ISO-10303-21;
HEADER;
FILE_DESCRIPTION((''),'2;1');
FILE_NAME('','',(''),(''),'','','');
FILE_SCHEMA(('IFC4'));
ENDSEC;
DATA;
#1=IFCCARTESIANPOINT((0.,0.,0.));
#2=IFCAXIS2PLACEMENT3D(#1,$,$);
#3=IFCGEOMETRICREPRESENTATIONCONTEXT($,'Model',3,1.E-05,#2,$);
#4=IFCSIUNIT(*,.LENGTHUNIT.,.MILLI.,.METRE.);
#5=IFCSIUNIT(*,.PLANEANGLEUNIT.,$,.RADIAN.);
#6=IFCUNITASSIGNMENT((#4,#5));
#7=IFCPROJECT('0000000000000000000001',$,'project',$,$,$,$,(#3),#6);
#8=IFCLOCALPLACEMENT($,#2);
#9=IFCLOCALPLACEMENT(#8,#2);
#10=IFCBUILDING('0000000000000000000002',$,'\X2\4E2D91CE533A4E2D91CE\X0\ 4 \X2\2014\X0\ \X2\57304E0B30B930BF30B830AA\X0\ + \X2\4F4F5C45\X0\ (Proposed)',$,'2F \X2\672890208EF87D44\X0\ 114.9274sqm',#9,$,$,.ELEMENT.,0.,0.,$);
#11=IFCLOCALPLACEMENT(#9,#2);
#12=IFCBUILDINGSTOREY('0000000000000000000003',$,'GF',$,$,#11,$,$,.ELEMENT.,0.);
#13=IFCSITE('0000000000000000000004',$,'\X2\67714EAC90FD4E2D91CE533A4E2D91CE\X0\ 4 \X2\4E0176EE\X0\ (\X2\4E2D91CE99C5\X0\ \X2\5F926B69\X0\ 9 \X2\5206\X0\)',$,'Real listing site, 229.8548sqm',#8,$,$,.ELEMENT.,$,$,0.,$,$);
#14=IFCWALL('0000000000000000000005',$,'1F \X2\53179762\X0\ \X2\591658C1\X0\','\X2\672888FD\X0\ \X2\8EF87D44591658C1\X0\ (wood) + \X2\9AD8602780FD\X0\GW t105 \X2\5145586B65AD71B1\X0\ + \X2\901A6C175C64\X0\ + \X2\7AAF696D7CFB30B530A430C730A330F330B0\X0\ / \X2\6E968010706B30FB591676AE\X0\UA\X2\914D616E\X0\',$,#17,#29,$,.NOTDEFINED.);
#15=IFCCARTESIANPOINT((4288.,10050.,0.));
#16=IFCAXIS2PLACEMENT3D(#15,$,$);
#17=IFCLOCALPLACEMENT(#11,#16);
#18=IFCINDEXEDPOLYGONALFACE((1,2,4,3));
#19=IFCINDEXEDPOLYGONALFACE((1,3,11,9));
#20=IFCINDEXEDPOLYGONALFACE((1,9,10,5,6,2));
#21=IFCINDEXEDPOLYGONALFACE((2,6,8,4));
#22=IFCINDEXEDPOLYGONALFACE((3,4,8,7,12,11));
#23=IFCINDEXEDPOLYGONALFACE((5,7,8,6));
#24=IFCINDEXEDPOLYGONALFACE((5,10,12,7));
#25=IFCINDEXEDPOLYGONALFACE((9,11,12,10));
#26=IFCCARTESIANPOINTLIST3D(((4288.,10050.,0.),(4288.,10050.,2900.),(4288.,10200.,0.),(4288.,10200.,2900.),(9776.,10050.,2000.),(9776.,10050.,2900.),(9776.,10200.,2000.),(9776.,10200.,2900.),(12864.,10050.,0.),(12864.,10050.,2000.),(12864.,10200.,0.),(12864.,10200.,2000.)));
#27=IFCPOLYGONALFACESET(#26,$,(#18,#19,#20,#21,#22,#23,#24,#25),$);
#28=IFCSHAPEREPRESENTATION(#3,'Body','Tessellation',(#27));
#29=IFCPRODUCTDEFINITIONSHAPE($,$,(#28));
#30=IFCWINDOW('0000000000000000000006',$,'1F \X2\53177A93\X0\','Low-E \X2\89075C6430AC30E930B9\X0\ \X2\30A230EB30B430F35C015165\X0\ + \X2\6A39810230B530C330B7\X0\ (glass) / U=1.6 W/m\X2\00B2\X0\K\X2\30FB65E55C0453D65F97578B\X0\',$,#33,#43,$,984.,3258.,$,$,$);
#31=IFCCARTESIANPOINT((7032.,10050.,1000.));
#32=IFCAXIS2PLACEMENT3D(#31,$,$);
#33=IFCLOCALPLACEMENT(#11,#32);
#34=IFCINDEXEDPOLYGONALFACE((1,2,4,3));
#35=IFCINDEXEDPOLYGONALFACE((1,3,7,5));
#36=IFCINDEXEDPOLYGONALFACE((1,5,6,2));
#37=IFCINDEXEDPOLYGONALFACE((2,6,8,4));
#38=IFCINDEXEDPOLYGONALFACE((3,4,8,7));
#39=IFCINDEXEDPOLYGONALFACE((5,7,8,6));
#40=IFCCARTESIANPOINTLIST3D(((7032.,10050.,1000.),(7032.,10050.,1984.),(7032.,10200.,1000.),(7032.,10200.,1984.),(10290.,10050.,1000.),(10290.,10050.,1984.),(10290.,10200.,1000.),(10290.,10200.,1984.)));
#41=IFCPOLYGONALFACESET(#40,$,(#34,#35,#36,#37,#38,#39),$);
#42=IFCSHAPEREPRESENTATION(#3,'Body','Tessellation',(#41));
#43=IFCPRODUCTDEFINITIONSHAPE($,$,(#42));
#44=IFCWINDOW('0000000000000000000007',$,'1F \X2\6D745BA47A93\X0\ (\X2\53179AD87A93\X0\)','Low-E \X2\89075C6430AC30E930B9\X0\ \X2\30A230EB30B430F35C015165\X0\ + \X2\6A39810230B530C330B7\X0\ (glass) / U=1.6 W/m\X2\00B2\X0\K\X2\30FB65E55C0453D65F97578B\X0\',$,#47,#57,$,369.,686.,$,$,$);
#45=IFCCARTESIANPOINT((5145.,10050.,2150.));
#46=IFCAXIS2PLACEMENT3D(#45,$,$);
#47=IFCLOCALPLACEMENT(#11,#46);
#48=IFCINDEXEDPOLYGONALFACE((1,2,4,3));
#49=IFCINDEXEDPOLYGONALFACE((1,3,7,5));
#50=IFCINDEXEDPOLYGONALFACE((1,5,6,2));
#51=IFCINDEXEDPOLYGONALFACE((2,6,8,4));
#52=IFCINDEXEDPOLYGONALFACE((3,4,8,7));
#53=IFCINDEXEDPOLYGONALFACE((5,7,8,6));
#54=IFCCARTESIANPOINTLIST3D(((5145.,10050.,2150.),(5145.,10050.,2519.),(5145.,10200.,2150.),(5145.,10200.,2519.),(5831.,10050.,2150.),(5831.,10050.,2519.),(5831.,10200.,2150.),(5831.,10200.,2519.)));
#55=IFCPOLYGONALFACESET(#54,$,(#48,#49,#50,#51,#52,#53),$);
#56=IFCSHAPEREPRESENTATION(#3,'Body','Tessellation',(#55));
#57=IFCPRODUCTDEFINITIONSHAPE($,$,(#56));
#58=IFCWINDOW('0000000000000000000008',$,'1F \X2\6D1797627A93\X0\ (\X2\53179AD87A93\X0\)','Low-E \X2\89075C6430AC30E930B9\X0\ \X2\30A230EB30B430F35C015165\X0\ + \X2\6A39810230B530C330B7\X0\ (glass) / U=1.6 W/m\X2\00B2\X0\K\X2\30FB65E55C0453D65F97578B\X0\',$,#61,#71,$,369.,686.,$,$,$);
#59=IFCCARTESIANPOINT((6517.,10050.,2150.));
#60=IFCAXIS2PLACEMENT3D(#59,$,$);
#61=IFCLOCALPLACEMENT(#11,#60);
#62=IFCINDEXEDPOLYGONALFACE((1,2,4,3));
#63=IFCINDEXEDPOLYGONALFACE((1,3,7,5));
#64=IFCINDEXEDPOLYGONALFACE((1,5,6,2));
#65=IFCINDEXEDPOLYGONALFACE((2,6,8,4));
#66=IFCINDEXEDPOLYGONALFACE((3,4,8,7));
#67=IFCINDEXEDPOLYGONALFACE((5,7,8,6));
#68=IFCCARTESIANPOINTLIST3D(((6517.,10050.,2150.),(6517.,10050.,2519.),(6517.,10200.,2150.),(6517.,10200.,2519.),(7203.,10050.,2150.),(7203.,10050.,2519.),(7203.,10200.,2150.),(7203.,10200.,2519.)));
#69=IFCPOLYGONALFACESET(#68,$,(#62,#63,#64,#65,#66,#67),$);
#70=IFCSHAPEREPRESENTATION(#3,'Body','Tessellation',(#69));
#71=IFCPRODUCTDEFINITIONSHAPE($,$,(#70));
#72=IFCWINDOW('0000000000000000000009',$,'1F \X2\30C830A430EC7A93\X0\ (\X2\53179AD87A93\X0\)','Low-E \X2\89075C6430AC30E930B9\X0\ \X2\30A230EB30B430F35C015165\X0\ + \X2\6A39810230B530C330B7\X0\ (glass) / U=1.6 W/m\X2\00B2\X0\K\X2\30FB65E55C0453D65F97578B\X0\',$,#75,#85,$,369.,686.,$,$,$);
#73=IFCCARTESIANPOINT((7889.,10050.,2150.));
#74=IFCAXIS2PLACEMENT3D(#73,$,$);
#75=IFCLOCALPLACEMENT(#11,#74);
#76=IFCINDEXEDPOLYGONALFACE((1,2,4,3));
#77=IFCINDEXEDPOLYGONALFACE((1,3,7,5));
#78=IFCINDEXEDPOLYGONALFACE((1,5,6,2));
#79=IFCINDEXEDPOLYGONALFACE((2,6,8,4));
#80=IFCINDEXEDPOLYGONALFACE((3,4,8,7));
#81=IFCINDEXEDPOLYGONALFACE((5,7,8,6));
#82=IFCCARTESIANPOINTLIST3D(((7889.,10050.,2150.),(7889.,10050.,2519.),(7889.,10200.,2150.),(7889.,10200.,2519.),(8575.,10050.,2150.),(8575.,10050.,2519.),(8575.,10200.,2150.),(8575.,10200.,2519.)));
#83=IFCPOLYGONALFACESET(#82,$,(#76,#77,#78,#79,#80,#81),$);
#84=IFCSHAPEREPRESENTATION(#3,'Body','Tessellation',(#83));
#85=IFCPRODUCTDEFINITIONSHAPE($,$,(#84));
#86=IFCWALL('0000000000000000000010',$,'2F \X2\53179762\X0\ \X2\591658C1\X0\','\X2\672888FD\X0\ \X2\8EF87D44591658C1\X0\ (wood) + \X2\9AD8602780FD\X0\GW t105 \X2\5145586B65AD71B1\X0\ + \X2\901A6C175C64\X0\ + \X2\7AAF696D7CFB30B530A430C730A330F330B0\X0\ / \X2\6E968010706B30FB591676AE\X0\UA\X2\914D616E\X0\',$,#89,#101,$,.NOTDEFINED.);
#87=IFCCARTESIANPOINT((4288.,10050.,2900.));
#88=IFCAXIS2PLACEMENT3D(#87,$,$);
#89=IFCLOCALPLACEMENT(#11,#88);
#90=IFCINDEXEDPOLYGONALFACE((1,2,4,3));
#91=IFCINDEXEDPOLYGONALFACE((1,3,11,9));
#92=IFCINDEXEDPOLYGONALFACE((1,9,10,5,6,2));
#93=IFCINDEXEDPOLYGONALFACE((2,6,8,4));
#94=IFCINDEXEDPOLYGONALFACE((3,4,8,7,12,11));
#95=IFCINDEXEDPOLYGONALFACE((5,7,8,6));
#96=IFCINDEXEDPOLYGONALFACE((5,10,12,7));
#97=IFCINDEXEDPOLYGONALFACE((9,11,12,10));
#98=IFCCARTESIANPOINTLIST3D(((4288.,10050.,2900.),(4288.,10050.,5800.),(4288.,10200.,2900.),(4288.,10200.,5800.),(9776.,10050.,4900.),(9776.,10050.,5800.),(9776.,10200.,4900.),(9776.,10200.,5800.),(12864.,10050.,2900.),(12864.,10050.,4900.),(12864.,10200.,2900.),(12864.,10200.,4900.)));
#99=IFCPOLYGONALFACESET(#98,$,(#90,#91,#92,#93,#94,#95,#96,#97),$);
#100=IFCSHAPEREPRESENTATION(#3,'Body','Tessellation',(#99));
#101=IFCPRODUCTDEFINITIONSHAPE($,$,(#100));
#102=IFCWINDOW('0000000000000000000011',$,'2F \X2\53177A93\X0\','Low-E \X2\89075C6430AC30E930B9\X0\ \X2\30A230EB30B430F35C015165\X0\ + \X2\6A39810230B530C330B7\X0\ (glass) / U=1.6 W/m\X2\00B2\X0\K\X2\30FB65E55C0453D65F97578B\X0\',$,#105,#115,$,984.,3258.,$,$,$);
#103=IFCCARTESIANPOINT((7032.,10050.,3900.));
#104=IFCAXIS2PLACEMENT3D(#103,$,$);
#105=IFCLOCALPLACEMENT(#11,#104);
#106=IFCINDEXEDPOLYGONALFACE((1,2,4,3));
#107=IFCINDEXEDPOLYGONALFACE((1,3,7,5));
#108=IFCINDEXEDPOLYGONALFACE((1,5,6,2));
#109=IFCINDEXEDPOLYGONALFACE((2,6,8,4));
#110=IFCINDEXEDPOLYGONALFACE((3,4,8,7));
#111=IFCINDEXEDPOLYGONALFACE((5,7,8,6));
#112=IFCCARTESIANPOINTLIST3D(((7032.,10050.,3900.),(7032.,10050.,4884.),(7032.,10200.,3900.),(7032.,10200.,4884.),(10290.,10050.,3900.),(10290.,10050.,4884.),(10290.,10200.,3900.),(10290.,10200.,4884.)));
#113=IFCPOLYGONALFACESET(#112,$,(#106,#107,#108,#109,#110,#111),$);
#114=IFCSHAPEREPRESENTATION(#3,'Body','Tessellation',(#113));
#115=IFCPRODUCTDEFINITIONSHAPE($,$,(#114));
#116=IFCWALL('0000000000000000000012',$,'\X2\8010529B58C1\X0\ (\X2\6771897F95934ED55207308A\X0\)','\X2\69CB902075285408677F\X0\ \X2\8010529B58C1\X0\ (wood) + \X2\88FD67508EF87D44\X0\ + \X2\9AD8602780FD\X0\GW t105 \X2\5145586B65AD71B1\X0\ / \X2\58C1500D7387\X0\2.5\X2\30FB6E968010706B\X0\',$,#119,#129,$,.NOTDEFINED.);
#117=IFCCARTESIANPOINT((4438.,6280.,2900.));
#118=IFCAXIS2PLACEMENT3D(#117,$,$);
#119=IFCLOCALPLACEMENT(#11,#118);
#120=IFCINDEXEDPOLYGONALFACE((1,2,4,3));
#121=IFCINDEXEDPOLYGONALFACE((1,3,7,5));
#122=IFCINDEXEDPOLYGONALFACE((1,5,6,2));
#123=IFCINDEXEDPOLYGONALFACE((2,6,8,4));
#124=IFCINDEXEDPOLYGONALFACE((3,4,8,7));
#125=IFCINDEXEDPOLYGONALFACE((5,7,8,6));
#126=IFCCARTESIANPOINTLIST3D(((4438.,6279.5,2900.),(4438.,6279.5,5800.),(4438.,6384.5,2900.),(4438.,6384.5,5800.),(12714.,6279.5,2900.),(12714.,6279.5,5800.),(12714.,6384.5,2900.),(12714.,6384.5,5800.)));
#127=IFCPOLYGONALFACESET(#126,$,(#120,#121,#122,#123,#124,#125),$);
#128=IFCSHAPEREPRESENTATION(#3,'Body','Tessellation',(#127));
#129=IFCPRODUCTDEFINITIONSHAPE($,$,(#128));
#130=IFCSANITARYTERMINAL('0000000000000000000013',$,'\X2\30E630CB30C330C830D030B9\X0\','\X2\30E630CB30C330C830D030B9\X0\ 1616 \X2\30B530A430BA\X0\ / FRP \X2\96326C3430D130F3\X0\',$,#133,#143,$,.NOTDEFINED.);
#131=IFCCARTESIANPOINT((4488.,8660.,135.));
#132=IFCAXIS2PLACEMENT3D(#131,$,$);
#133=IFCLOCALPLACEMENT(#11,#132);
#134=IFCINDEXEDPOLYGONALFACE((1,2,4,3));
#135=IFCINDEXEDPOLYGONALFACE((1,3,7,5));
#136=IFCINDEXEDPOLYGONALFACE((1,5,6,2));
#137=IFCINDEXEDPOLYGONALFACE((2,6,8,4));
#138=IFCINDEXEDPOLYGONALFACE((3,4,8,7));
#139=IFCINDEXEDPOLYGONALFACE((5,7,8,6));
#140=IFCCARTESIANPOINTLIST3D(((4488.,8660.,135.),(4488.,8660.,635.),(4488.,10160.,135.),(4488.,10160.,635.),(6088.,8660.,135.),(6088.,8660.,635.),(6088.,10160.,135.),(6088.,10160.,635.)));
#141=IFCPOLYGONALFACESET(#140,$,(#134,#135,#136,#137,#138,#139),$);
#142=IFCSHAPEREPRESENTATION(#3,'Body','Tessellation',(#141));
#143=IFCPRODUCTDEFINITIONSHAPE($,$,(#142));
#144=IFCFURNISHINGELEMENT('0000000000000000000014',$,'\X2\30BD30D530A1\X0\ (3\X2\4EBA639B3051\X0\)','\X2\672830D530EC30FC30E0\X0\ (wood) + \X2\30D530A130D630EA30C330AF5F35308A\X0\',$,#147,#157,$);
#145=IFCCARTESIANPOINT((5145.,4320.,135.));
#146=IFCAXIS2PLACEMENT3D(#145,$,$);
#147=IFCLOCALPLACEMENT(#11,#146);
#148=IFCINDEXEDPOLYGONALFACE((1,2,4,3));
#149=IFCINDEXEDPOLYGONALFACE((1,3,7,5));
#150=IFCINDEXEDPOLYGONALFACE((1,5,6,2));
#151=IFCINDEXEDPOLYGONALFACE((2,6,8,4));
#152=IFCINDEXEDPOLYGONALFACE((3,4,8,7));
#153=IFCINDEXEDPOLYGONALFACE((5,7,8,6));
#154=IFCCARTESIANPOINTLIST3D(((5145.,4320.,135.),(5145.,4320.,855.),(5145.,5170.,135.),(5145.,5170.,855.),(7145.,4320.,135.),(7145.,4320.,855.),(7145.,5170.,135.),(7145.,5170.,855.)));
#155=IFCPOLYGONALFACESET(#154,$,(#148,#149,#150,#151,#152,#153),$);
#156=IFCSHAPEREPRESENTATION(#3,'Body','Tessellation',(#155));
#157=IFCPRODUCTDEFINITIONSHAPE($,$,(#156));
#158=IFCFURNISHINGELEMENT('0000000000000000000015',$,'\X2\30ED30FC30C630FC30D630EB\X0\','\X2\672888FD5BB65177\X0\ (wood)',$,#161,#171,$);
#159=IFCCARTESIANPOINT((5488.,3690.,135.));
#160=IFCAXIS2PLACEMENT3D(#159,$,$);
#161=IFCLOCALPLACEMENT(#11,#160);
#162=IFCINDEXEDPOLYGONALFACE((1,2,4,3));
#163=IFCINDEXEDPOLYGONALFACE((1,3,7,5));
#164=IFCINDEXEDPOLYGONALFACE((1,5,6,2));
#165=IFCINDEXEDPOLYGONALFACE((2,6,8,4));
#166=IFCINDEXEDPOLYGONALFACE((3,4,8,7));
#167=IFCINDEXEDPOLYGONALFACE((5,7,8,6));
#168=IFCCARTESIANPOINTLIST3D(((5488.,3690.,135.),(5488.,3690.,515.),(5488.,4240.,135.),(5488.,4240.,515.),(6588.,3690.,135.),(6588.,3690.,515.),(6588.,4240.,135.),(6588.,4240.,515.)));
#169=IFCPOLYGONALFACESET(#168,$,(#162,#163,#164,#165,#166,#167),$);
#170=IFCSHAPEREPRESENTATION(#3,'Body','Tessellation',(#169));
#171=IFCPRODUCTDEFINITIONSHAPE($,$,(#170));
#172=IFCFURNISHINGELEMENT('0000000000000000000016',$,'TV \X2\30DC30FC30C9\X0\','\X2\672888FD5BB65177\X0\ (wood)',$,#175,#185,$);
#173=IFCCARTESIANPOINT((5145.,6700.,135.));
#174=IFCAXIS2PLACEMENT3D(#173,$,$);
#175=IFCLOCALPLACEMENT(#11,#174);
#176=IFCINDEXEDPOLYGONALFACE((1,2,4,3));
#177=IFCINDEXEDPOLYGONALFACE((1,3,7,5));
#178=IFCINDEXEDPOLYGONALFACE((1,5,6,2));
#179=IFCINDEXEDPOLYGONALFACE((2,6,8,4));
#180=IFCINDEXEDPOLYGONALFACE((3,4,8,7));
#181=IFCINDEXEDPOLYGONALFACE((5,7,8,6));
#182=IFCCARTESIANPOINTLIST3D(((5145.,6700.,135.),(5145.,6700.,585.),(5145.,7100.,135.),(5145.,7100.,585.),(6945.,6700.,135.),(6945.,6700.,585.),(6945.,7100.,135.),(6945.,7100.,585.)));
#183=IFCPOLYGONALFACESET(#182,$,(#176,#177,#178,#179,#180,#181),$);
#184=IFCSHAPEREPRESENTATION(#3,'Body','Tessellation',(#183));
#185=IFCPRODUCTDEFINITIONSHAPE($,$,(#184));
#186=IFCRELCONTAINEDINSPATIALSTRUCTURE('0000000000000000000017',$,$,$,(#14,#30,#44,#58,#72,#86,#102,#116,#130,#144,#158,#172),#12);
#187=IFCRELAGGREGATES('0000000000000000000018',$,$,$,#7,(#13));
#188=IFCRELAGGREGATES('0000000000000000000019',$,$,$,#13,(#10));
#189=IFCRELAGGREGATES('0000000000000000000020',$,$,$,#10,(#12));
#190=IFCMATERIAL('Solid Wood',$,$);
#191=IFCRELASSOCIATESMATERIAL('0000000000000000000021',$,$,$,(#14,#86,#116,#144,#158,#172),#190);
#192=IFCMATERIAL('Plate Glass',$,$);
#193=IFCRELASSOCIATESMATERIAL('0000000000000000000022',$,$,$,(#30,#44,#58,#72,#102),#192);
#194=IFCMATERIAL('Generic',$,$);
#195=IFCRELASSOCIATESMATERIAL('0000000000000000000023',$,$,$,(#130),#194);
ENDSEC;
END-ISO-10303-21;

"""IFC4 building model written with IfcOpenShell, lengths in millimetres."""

from ifc_helpers import new_model, si_unit, frame, frame_2d, origin, place, context, project, spatial, rectangle, extrude, material, element, fill, save


model = new_model("IFC4")

# Units and contexts
model_context = context("Model", 3, precision=1e-05, world=origin())
ifc_project = project(units=[si_unit("LENGTHUNIT", "METRE", prefix="MILLI"), si_unit("PLANEANGLEUNIT", "RADIAN")], contexts=[model_context])

# Site, building, storey
site_placement = place(None, origin())
site = spatial("IfcSite", under=ifc_project, at=site_placement, Name="東京都中野区中野 4 丁目 (中野駅 徒歩 9 分)", ObjectType="Real listing site, 229.8548sqm", CompositionType="ELEMENT", RefElevation=0.0)
building_placement = place(site_placement, origin())
building = spatial("IfcBuilding", under=site, at=building_placement, Name="中野区中野 4 — 地下スタジオ + 住居 (Proposed)", ObjectType="2F 木造軸組 114.9274sqm", CompositionType="ELEMENT", ElevationOfRefHeight=0.0, ElevationOfTerrain=0.0)
storey_placement = place(building_placement, origin())
storey = spatial("IfcBuildingStorey", under=building, at=storey_placement, Name="GF", CompositionType="ELEMENT", Elevation=0.0)

# Wall, openings, windows
ifc_material_1 = material(Name="Solid Wood")
wall_1_placement = place(storey_placement, frame((4288.0, 10050.0, 0.0)))
wall_1 = element("IfcWall", 1, at=wall_1_placement, inside=storey, material=ifc_material_1, Name="1F 北面 外壁", Description="木製 軸組外壁 (wood) + 高性能GW t105 充填断熱 + 通気層 + 窯業系サイディング / 準耐火・外皮UA配慮", PredefinedType="NOTDEFINED", context=model_context, shape_type="SweptSolid", body=[
    extrude(rectangle(XDim=8576.0, YDim=150.0, at=frame_2d((4288.0, 75.0))), frame((4288.0, 10050.0, 0.0)), (0.0, 0.0, 1.0), 2900.0),
])
opening_1_placement = place(storey_placement, frame((7032.0, 10050.0, 1000.0)))
opening_1 = element("IfcOpeningElement", 2, at=opening_1_placement, cuts=wall_1, PredefinedType="NOTDEFINED", context=model_context, shape_type="SweptSolid", body=[
    extrude(rectangle(XDim=3258.0, YDim=150.0, at=frame_2d((1629.0, 75.0))), frame((7032.0, 10050.0, 1000.0)), (0.0, 0.0, 1.0), 984.0),
])
opening_2_placement = place(storey_placement, frame((5145.0, 10050.0, 2150.0)))
opening_2 = element("IfcOpeningElement", 3, at=opening_2_placement, cuts=wall_1, PredefinedType="NOTDEFINED", context=model_context, shape_type="SweptSolid", body=[
    extrude(rectangle(XDim=686.0, YDim=150.0, at=frame_2d((343.0, 75.0))), frame((5145.0, 10050.0, 2150.0)), (0.0, 0.0, 1.0), 369.0),
])
opening_3_placement = place(storey_placement, frame((6517.0, 10050.0, 2150.0)))
opening_3 = element("IfcOpeningElement", 4, at=opening_3_placement, cuts=wall_1, PredefinedType="NOTDEFINED", context=model_context, shape_type="SweptSolid", body=[
    extrude(rectangle(XDim=686.0, YDim=150.0, at=frame_2d((343.0, 75.0))), frame((6517.0, 10050.0, 2150.0)), (0.0, 0.0, 1.0), 369.0),
])
opening_4_placement = place(storey_placement, frame((7889.0, 10050.0, 2150.0)))
opening_4 = element("IfcOpeningElement", 5, at=opening_4_placement, cuts=wall_1, PredefinedType="NOTDEFINED", context=model_context, shape_type="SweptSolid", body=[
    extrude(rectangle(XDim=686.0, YDim=150.0, at=frame_2d((343.0, 75.0))), frame((7889.0, 10050.0, 2150.0)), (0.0, 0.0, 1.0), 369.0),
])
ifc_material_2 = material(Name="Plate Glass")
window_1_placement = place(storey_placement, frame((7032.0, 10050.0, 1000.0)))
window_1 = element("IfcWindow", 6, at=window_1_placement, inside=storey, material=ifc_material_2, Name="1F 北窓", Description="Low-E 複層ガラス アルゴン封入 + 樹脂サッシ (glass) / U=1.6 W/m²K・日射取得型", OverallHeight=984.0, OverallWidth=3258.0, context=model_context, shape_type="SweptSolid", body=[
    extrude(rectangle(XDim=3258.0, YDim=150.0, at=frame_2d((1629.0, 75.0))), frame((7032.0, 10050.0, 1000.0)), (0.0, 0.0, 1.0), 984.0),
])
fill(opening_1, window_1)
window_2_placement = place(storey_placement, frame((5145.0, 10050.0, 2150.0)))
window_2 = element("IfcWindow", 7, at=window_2_placement, inside=storey, material=ifc_material_2, Name="1F 浴室窓 (北高窓)", Description="Low-E 複層ガラス アルゴン封入 + 樹脂サッシ (glass) / U=1.6 W/m²K・日射取得型", OverallHeight=369.0, OverallWidth=686.0, context=model_context, shape_type="SweptSolid", body=[
    extrude(rectangle(XDim=686.0, YDim=150.0, at=frame_2d((343.0, 75.0))), frame((5145.0, 10050.0, 2150.0)), (0.0, 0.0, 1.0), 369.0),
])
fill(opening_2, window_2)
window_3_placement = place(storey_placement, frame((6517.0, 10050.0, 2150.0)))
window_3 = element("IfcWindow", 8, at=window_3_placement, inside=storey, material=ifc_material_2, Name="1F 洗面窓 (北高窓)", Description="Low-E 複層ガラス アルゴン封入 + 樹脂サッシ (glass) / U=1.6 W/m²K・日射取得型", OverallHeight=369.0, OverallWidth=686.0, context=model_context, shape_type="SweptSolid", body=[
    extrude(rectangle(XDim=686.0, YDim=150.0, at=frame_2d((343.0, 75.0))), frame((6517.0, 10050.0, 2150.0)), (0.0, 0.0, 1.0), 369.0),
])
fill(opening_3, window_3)
window_4_placement = place(storey_placement, frame((7889.0, 10050.0, 2150.0)))
window_4 = element("IfcWindow", 9, at=window_4_placement, inside=storey, material=ifc_material_2, Name="1F トイレ窓 (北高窓)", Description="Low-E 複層ガラス アルゴン封入 + 樹脂サッシ (glass) / U=1.6 W/m²K・日射取得型", OverallHeight=369.0, OverallWidth=686.0, context=model_context, shape_type="SweptSolid", body=[
    extrude(rectangle(XDim=686.0, YDim=150.0, at=frame_2d((343.0, 75.0))), frame((7889.0, 10050.0, 2150.0)), (0.0, 0.0, 1.0), 369.0),
])
fill(opening_4, window_4)

# Wall, opening, window
wall_2_placement = place(storey_placement, frame((4288.0, 10050.0, 2900.0)))
wall_2 = element("IfcWall", 10, at=wall_2_placement, inside=storey, material=ifc_material_1, Name="2F 北面 外壁", Description="木製 軸組外壁 (wood) + 高性能GW t105 充填断熱 + 通気層 + 窯業系サイディング / 準耐火・外皮UA配慮", PredefinedType="NOTDEFINED", context=model_context, shape_type="SweptSolid", body=[
    extrude(rectangle(XDim=8576.0, YDim=150.0, at=frame_2d((4288.0, 75.0))), frame((4288.0, 10050.0, 2900.0)), (0.0, 0.0, 1.0), 2900.0),
])
opening_5_placement = place(storey_placement, frame((7032.0, 10050.0, 3900.0)))
opening_5 = element("IfcOpeningElement", 11, at=opening_5_placement, cuts=wall_2, PredefinedType="NOTDEFINED", context=model_context, shape_type="SweptSolid", body=[
    extrude(rectangle(XDim=3258.0, YDim=150.0, at=frame_2d((1629.0, 75.0))), frame((7032.0, 10050.0, 3900.0)), (0.0, 0.0, 1.0), 984.0),
])
window_5_placement = place(storey_placement, frame((7032.0, 10050.0, 3900.0)))
window_5 = element("IfcWindow", 12, at=window_5_placement, inside=storey, material=ifc_material_2, Name="2F 北窓", Description="Low-E 複層ガラス アルゴン封入 + 樹脂サッシ (glass) / U=1.6 W/m²K・日射取得型", OverallHeight=984.0, OverallWidth=3258.0, context=model_context, shape_type="SweptSolid", body=[
    extrude(rectangle(XDim=3258.0, YDim=150.0, at=frame_2d((1629.0, 75.0))), frame((7032.0, 10050.0, 3900.0)), (0.0, 0.0, 1.0), 984.0),
])
fill(opening_5, window_5)

# Wall
wall_3_placement = place(storey_placement, frame((4438.0, 6280.0, 2900.0)))
element("IfcWall", 13, at=wall_3_placement, inside=storey, material=ifc_material_1, Name="耐力壁 (東西間仕切り)", Description="構造用合板 耐力壁 (wood) + 製材軸組 + 高性能GW t105 充填断熱 / 壁倍率2.5・準耐火", PredefinedType="NOTDEFINED", context=model_context, shape_type="SweptSolid", body=[
    extrude(rectangle(XDim=8276.0, YDim=105.0, at=frame_2d((4138.0, 52.0))), frame((4438.0, 6280.0, 2900.0)), (0.0, 0.0, 1.0), 2900.0),
])

# Sanitary terminal
ifc_material_3 = material(Name="Generic")
sanitary_terminal_placement = place(storey_placement, frame((4488.0, 8660.0, 135.0)))
element("IfcSanitaryTerminal", 14, at=sanitary_terminal_placement, inside=storey, material=ifc_material_3, Name="ユニットバス", Description="ユニットバス 1616 サイズ / FRP 防水パン", PredefinedType="NOTDEFINED", context=model_context, shape_type="SweptSolid", body=[
    extrude(rectangle(XDim=1600.0, YDim=1500.0, at=frame_2d((800.0, 750.0))), frame((4488.0, 8660.0, 135.0)), (0.0, 0.0, 1.0), 500.0),
])

# Furnishing elements
furnishing_1_placement = place(storey_placement, frame((5145.0, 4320.0, 135.0)))
element("IfcFurnishingElement", 15, at=furnishing_1_placement, inside=storey, material=ifc_material_1, Name="ソファ (3人掛け)", Description="木フレーム (wood) + ファブリック張り", context=model_context, shape_type="SweptSolid", body=[
    extrude(rectangle(XDim=2000.0, YDim=850.0, at=frame_2d((1000.0, 425.0))), frame((5145.0, 4320.0, 135.0)), (0.0, 0.0, 1.0), 720.0),
])
furnishing_2_placement = place(storey_placement, frame((5488.0, 3690.0, 135.0)))
element("IfcFurnishingElement", 16, at=furnishing_2_placement, inside=storey, material=ifc_material_1, Name="ローテーブル", Description="木製家具 (wood)", context=model_context, shape_type="SweptSolid", body=[
    extrude(rectangle(XDim=1100.0, YDim=550.0, at=frame_2d((550.0, 275.0))), frame((5488.0, 3690.0, 135.0)), (0.0, 0.0, 1.0), 380.0),
])
furnishing_3_placement = place(storey_placement, frame((5145.0, 6700.0, 135.0)))
element("IfcFurnishingElement", 17, at=furnishing_3_placement, inside=storey, material=ifc_material_1, Name="TV ボード", Description="木製家具 (wood)", context=model_context, shape_type="SweptSolid", body=[
    extrude(rectangle(XDim=1800.0, YDim=400.0, at=frame_2d((900.0, 200.0))), frame((5145.0, 6700.0, 135.0)), (0.0, 0.0, 1.0), 450.0),
])

save(model, "model.ifc")
